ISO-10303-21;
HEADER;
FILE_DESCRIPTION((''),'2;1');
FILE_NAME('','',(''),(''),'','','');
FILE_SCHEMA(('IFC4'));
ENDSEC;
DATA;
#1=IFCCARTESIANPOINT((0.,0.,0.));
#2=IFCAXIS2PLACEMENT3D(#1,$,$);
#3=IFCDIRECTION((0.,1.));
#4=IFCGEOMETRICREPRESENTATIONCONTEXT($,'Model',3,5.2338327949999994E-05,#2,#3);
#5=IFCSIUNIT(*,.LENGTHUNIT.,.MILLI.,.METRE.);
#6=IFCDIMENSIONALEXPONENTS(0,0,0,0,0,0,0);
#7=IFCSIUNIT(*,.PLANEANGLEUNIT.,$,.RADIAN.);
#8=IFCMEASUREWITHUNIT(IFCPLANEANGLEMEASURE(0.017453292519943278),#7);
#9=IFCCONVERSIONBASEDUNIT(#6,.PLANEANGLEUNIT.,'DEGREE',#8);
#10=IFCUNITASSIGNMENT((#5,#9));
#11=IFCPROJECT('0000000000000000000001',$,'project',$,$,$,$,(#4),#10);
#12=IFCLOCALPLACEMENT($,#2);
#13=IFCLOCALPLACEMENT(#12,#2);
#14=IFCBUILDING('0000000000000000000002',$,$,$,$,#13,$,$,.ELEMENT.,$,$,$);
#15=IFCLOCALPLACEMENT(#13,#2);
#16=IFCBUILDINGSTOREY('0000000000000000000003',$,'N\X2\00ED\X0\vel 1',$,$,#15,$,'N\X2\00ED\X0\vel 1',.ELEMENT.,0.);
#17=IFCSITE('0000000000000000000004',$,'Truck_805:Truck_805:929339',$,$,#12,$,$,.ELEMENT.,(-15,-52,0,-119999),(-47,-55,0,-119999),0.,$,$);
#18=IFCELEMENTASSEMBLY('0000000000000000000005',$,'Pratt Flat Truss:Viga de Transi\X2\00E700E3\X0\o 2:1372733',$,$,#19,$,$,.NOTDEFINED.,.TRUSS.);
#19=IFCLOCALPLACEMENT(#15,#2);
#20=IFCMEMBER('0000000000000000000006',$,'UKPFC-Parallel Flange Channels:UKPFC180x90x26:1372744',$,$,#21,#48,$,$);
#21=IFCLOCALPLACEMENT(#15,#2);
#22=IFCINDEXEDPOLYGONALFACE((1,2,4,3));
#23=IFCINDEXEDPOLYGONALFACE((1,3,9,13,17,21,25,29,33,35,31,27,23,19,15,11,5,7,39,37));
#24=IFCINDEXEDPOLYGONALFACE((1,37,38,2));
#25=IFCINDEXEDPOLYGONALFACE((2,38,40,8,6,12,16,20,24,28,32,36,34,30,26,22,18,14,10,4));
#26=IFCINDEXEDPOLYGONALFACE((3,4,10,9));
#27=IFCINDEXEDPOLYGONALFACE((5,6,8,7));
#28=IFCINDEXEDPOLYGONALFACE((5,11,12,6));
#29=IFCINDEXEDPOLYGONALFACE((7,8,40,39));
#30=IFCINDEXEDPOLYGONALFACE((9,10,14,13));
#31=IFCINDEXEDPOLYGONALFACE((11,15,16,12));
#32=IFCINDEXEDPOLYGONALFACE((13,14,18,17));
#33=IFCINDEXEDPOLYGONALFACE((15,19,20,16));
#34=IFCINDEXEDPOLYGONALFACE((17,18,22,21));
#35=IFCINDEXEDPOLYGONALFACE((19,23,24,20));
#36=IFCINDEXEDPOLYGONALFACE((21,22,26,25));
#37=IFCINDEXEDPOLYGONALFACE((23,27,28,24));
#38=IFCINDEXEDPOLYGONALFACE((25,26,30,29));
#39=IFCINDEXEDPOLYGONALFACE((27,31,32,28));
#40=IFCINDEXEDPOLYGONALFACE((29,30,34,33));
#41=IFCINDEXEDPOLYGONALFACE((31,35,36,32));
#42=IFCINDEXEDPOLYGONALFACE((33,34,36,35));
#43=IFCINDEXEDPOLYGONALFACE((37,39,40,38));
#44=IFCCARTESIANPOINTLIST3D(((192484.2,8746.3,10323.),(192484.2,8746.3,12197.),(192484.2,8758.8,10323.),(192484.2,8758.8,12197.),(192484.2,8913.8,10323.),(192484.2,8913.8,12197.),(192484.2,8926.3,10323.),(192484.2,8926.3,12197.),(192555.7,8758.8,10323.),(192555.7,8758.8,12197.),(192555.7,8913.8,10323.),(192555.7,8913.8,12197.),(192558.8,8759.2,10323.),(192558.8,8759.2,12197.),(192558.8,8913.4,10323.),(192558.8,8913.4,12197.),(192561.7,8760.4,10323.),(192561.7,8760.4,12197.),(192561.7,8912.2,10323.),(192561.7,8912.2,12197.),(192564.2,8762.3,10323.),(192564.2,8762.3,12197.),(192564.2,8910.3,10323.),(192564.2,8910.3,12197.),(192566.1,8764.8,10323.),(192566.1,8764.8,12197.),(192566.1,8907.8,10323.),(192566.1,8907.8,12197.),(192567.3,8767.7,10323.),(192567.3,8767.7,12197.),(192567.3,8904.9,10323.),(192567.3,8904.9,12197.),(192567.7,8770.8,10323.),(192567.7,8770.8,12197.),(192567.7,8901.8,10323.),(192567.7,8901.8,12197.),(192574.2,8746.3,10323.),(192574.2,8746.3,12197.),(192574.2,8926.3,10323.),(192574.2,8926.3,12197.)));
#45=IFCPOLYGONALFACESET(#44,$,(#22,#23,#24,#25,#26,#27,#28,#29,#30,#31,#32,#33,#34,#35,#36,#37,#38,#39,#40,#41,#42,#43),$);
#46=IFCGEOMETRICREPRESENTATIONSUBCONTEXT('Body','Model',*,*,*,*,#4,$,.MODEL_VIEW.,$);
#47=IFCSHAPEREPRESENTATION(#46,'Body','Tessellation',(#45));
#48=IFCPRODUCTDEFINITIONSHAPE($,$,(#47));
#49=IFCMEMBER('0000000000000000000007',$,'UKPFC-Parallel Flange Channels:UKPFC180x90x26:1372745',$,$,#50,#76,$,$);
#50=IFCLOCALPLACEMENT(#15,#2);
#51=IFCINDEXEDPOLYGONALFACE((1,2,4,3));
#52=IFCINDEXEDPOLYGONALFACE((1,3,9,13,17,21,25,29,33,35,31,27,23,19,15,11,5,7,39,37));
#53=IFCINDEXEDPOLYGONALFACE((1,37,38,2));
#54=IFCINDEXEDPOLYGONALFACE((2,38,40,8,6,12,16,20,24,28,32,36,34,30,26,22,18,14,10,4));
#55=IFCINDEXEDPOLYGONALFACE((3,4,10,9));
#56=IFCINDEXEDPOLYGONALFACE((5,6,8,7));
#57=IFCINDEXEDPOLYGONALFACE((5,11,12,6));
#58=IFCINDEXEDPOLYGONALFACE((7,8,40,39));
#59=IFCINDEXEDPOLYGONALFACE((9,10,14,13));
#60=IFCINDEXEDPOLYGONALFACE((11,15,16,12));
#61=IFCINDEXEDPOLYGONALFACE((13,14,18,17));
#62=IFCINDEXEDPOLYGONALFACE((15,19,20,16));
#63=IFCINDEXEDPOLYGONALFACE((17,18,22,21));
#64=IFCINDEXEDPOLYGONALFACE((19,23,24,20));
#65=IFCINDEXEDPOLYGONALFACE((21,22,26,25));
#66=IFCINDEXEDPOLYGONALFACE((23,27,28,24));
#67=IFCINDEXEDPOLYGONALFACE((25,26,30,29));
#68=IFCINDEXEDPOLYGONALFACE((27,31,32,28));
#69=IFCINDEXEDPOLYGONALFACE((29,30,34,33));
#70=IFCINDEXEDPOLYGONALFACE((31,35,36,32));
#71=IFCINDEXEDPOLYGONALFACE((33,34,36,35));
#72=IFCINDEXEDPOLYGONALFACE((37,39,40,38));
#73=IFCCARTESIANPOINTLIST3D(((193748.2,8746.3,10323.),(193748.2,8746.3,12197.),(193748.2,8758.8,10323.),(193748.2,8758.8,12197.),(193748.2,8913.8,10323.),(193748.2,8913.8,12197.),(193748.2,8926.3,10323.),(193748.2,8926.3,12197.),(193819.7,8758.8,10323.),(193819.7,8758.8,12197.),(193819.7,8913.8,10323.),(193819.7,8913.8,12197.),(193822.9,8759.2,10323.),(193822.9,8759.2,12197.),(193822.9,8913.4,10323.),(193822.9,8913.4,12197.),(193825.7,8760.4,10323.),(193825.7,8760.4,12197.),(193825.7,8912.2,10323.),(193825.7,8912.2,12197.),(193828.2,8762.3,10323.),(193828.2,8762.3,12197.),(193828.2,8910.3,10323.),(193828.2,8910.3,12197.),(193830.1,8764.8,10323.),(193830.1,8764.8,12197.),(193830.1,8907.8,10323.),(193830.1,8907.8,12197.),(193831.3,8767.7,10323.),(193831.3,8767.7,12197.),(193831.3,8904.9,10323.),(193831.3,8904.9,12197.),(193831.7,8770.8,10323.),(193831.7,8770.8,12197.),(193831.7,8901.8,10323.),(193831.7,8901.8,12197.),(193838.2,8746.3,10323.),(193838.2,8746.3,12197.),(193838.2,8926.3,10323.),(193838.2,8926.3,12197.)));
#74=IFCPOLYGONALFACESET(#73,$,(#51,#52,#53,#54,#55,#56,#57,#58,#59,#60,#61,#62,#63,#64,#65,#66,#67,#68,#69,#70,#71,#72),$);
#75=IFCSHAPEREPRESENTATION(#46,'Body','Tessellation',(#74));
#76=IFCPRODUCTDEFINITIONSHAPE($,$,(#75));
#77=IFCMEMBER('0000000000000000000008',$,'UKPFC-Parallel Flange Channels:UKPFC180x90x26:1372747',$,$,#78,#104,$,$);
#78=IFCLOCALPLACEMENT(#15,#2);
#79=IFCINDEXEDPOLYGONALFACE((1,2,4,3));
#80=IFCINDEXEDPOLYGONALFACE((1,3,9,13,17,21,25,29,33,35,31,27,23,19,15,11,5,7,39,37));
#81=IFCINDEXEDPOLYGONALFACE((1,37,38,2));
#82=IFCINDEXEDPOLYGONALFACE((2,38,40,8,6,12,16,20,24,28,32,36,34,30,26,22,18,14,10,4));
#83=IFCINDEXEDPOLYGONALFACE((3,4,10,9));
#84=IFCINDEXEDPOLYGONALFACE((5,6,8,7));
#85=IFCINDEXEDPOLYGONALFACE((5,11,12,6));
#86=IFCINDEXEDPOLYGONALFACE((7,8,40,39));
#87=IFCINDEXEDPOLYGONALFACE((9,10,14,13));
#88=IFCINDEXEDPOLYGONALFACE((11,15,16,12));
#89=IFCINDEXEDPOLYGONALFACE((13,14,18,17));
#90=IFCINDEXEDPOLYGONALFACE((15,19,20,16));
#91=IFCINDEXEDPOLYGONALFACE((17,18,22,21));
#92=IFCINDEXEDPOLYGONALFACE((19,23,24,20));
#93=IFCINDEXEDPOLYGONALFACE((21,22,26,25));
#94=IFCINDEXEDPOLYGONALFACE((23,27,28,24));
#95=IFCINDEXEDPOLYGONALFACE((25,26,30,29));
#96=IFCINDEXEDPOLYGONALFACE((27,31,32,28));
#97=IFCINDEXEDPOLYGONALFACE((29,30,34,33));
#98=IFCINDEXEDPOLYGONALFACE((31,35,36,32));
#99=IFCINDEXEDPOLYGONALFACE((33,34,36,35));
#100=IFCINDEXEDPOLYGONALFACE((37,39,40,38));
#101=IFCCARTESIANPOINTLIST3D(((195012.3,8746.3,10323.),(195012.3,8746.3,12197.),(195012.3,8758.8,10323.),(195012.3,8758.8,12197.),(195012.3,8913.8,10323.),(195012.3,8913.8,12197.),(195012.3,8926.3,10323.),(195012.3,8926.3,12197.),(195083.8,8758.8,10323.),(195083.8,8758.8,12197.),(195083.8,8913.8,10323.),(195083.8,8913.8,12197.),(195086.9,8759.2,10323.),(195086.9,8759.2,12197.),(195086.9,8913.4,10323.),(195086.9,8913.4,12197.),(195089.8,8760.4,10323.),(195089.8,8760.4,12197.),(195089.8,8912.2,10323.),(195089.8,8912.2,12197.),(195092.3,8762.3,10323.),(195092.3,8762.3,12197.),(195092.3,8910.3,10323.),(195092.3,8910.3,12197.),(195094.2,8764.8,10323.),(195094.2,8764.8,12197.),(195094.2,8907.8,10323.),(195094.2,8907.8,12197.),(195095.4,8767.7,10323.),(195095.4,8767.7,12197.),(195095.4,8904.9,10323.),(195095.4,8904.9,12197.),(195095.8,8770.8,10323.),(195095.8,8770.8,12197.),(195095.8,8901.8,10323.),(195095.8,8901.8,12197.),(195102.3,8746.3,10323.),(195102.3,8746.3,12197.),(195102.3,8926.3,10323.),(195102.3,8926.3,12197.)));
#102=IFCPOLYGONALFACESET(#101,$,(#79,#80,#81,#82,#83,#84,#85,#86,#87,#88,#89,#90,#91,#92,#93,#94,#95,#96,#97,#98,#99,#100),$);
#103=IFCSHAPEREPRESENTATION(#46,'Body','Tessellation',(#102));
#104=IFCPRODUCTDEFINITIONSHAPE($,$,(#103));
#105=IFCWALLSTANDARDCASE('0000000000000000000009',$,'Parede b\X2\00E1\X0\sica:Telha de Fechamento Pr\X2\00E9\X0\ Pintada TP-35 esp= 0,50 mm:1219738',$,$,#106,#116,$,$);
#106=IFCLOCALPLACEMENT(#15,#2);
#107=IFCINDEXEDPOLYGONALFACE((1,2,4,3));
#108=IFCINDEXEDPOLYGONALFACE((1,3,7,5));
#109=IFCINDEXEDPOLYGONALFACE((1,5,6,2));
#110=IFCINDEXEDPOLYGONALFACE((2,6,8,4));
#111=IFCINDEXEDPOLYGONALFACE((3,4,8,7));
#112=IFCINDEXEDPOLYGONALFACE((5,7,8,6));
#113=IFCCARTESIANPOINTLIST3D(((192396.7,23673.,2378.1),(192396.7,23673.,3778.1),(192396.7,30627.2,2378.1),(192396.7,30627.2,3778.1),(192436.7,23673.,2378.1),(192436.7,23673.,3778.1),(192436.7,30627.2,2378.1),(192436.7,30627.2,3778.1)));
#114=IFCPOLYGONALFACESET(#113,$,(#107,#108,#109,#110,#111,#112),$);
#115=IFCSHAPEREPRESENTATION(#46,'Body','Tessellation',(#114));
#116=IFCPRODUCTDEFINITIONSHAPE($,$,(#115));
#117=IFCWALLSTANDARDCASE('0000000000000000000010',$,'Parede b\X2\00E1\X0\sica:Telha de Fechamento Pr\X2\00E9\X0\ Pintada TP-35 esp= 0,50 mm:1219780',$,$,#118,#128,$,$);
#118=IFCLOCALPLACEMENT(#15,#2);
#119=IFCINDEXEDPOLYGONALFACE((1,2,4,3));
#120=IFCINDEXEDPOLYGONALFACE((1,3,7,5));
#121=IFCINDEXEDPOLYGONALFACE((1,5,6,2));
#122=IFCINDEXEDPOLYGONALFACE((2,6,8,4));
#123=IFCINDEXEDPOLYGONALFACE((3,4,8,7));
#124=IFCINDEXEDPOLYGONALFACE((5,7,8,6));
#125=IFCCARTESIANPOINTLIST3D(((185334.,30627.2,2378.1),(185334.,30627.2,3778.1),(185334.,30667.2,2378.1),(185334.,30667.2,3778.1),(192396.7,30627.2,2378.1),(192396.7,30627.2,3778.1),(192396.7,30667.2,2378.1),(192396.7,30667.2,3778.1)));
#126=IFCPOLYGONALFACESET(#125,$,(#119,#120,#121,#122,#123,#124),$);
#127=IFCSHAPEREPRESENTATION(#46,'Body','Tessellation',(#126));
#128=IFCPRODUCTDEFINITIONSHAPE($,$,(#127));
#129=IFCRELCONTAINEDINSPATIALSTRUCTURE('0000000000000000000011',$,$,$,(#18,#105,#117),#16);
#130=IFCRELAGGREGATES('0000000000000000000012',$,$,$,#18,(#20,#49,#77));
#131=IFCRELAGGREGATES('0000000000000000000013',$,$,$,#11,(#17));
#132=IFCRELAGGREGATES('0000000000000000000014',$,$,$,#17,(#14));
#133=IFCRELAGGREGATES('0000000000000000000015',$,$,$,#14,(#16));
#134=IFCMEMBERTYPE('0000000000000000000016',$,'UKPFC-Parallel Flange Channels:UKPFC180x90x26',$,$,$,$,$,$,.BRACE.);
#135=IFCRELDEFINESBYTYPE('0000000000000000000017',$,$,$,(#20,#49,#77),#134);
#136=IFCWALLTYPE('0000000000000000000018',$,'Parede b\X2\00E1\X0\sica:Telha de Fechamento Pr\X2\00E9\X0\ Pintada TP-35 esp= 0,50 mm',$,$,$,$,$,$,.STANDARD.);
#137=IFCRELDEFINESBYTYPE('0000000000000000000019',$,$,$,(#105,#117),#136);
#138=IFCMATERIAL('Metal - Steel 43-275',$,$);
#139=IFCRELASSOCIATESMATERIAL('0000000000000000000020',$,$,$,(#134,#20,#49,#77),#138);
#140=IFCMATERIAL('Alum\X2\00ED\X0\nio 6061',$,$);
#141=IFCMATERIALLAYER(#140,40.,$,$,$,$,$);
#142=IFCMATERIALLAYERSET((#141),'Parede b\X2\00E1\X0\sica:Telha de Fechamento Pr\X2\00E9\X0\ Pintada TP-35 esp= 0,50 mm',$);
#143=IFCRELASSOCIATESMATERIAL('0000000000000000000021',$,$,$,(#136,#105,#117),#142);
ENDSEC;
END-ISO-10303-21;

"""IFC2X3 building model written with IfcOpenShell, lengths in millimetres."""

from ifc_helpers import new_model, entity, si_unit, converted_unit, direction, frame, frame_2d, origin, place, context, subcontext, project, spatial, polyline, circle_curve, parameter, trimmed, segment, composite_curve, rectangle, outline, extrude, source, transform, mapped, material, layer, layer_set, layer_usage, type_object, type_shapes, element, aggregate, save


model = new_model("IFC2X3")

# Units and contexts
model_context = context("Model", 3, precision=5.2338327949999994e-05, world=origin(), true_north=direction((0.0, 1.0)))
body_context = subcontext(model_context, "Body", "Model", "MODEL_VIEW")
ifc_project = project(units=[si_unit("LENGTHUNIT", "METRE", prefix="MILLI"), converted_unit("PLANEANGLEUNIT", "DEGREE", entity("IfcPlaneAngleMeasure", 0.017453292519943278), si_unit("PLANEANGLEUNIT", "RADIAN"), dimensions=[0, 0, 0, 0, 0, 0, 0])], contexts=[model_context])

# Site, building, storey
site_placement = place(None, origin())
site = spatial("IfcSite", under=ifc_project, at=site_placement, Name="Truck_805:Truck_805:929339", CompositionType="ELEMENT", RefLatitude=(-15, -52, 0, -119999), RefLongitude=(-47, -55, 0, -119999), RefElevation=0.0)
building_placement = place(site_placement, origin())
building = spatial("IfcBuilding", under=site, at=building_placement, CompositionType="ELEMENT")
storey_placement = place(building_placement, origin())
storey = spatial("IfcBuildingStorey", under=building, at=storey_placement, Name="Nível 1", LongName="Nível 1", CompositionType="ELEMENT", Elevation=0.0)

# Element assembly, members
assembly_1_placement = place(storey_placement, origin())
assembly_1 = element("IfcElementAssembly", 1, at=assembly_1_placement, inside=storey, Name="Pratt Flat Truss:Viga de Transição 2:1372733", AssemblyPlace="NOTDEFINED", PredefinedType="TRUSS")
ifc_material_1 = material(Name="Metal - Steel 43-275")
member_type_1 = type_object("IfcMemberType", Name="UKPFC-Parallel Flange Channels:UKPFC180x90x26", PredefinedType="BRACE", material=ifc_material_1)
shared_shape_1 = source(origin(), body_context, "Body", "SweptSolid", [
    extrude(outline(composite_curve([segment(polyline([(-90.0, -49.0), (-77.5, -49.0)]), True, "CONTINUOUS"), segment(polyline([(-77.5, -49.0), (-77.5, 22.5)]), True, "CONTINUOUS"), segment(trimmed(circle_curve(frame_2d((-65.5, 22.5), x_axis=(-1.0, 0.0)), 12.0), [parameter(270.0)], [parameter(0.0)], True, "PARAMETER"), False, "CONTINUOUS"), segment(polyline([(-65.5, 34.5), (65.5, 34.5)]), True, "CONTINUOUS"), segment(trimmed(circle_curve(frame_2d((65.5, 22.5), x_axis=(0.0, 1.0)), 12.0), [parameter(270.0)], [parameter(0.0)], True, "PARAMETER"), False, "CONTINUOUS"), segment(polyline([(77.5, 22.5), (77.5, -49.0)]), True, "CONTINUOUS"), segment(polyline([(77.5, -49.0), (90.0, -49.0)]), True, "CONTINUOUS"), segment(polyline([(90.0, -49.0), (90.0, 41.0)]), True, "CONTINUOUS"), segment(polyline([(90.0, 41.0), (-90.0, 41.0)]), True, "CONTINUOUS"), segment(polyline([(-90.0, 41.0), (-90.0, -49.0)]), True, "CONTINUOUS")], self_intersect=False)), frame((-937.0, -9.3, 0.0), z_axis=(1.0, 0.0, 0.0), x_axis=(0.0, 0.0, -1.0)), (0.0, 0.0, 1.0), 1874.0),
])
type_shapes(member_type_1, [shared_shape_1])
member_1_placement = place(assembly_1_placement, frame((192542.5, 8836.3, 11260.0), z_axis=(0.0, 1.0, 0.0), x_axis=(0.0, 0.0, 1.0)))
member_1 = element("IfcMember", 2, at=member_1_placement, type_object=member_type_1, material=ifc_material_1, Name="UKPFC-Parallel Flange Channels:UKPFC180x90x26:1372744", context=body_context, shape_type="MappedRepresentation", body=[
    mapped(shared_shape_1, transform((0.0, 0.0, 0.0), scale=1.0)),
])
member_2_placement = place(assembly_1_placement, frame((193806.5, 8836.3, 11260.0), z_axis=(0.0, 1.0, 0.0), x_axis=(0.0, 0.0, 1.0)))
member_2 = element("IfcMember", 3, at=member_2_placement, type_object=member_type_1, material=ifc_material_1, Name="UKPFC-Parallel Flange Channels:UKPFC180x90x26:1372745", context=body_context, shape_type="MappedRepresentation", body=[
    mapped(shared_shape_1, transform((0.0, 0.0, 0.0), scale=1.0)),
])
member_3_placement = place(assembly_1_placement, frame((195070.6, 8836.3, 11260.0), z_axis=(0.0, 1.0, 0.0), x_axis=(0.0, 0.0, 1.0)))
member_3 = element("IfcMember", 4, at=member_3_placement, type_object=member_type_1, material=ifc_material_1, Name="UKPFC-Parallel Flange Channels:UKPFC180x90x26:1372747", context=body_context, shape_type="MappedRepresentation", body=[
    mapped(shared_shape_1, transform((0.0, 0.0, 0.0), scale=1.0)),
])
aggregate(assembly_1, [member_1, member_2, member_3])

# Walls
ifc_material_2 = material(Name="Alumínio 6061")
ifc_layer = layer(ifc_material_2, 40.0)
ifc_layer_set = layer_set([ifc_layer], Name="Parede básica:Telha de Fechamento Pré Pintada TP-35 esp= 0,50 mm")
ifc_layer_usage_1 = layer_usage(ifc_layer_set, "AXIS2", "NEGATIVE", 20.0)
wall_type = type_object("IfcWallType", Name="Parede básica:Telha de Fechamento Pré Pintada TP-35 esp= 0,50 mm", PredefinedType="STANDARD", material=ifc_layer_set)
wall_1_placement = place(storey_placement, frame((192416.7, 23673.0, 2378.1), z_axis=(0.0, 0.0, 1.0), x_axis=(0.0, 1.0, 0.0)))
element("IfcWallStandardCase", 5, at=wall_1_placement, inside=storey, type_object=wall_type, material=ifc_layer_usage_1, Name="Parede básica:Telha de Fechamento Pré Pintada TP-35 esp= 0,50 mm:1219738", context=body_context, shape_type="SweptSolid", body=[
    extrude(rectangle(XDim=6954.2, YDim=40.0, at=frame_2d((3477.1, 0.0), x_axis=(-1.0, 0.0))), origin(), (0.0, 0.0, 1.0), 1400.0),
])
ifc_layer_usage_2 = layer_usage(ifc_layer_set, "AXIS2", "NEGATIVE", 20.0)
wall_2_placement = place(storey_placement, frame((192396.7, 30647.2, 2378.1), z_axis=(0.0, 0.0, 1.0), x_axis=(-1.0, 0.0, 0.0)))
element("IfcWallStandardCase", 6, at=wall_2_placement, inside=storey, type_object=wall_type, material=ifc_layer_usage_2, Name="Parede básica:Telha de Fechamento Pré Pintada TP-35 esp= 0,50 mm:1219780", context=body_context, shape_type="SweptSolid", body=[
    extrude(rectangle(XDim=7062.7, YDim=40.0, at=frame_2d((3531.3, 0.0), x_axis=(-1.0, 0.0))), origin(), (0.0, 0.0, 1.0), 1400.0),
])

save(model, "model.ifc")
